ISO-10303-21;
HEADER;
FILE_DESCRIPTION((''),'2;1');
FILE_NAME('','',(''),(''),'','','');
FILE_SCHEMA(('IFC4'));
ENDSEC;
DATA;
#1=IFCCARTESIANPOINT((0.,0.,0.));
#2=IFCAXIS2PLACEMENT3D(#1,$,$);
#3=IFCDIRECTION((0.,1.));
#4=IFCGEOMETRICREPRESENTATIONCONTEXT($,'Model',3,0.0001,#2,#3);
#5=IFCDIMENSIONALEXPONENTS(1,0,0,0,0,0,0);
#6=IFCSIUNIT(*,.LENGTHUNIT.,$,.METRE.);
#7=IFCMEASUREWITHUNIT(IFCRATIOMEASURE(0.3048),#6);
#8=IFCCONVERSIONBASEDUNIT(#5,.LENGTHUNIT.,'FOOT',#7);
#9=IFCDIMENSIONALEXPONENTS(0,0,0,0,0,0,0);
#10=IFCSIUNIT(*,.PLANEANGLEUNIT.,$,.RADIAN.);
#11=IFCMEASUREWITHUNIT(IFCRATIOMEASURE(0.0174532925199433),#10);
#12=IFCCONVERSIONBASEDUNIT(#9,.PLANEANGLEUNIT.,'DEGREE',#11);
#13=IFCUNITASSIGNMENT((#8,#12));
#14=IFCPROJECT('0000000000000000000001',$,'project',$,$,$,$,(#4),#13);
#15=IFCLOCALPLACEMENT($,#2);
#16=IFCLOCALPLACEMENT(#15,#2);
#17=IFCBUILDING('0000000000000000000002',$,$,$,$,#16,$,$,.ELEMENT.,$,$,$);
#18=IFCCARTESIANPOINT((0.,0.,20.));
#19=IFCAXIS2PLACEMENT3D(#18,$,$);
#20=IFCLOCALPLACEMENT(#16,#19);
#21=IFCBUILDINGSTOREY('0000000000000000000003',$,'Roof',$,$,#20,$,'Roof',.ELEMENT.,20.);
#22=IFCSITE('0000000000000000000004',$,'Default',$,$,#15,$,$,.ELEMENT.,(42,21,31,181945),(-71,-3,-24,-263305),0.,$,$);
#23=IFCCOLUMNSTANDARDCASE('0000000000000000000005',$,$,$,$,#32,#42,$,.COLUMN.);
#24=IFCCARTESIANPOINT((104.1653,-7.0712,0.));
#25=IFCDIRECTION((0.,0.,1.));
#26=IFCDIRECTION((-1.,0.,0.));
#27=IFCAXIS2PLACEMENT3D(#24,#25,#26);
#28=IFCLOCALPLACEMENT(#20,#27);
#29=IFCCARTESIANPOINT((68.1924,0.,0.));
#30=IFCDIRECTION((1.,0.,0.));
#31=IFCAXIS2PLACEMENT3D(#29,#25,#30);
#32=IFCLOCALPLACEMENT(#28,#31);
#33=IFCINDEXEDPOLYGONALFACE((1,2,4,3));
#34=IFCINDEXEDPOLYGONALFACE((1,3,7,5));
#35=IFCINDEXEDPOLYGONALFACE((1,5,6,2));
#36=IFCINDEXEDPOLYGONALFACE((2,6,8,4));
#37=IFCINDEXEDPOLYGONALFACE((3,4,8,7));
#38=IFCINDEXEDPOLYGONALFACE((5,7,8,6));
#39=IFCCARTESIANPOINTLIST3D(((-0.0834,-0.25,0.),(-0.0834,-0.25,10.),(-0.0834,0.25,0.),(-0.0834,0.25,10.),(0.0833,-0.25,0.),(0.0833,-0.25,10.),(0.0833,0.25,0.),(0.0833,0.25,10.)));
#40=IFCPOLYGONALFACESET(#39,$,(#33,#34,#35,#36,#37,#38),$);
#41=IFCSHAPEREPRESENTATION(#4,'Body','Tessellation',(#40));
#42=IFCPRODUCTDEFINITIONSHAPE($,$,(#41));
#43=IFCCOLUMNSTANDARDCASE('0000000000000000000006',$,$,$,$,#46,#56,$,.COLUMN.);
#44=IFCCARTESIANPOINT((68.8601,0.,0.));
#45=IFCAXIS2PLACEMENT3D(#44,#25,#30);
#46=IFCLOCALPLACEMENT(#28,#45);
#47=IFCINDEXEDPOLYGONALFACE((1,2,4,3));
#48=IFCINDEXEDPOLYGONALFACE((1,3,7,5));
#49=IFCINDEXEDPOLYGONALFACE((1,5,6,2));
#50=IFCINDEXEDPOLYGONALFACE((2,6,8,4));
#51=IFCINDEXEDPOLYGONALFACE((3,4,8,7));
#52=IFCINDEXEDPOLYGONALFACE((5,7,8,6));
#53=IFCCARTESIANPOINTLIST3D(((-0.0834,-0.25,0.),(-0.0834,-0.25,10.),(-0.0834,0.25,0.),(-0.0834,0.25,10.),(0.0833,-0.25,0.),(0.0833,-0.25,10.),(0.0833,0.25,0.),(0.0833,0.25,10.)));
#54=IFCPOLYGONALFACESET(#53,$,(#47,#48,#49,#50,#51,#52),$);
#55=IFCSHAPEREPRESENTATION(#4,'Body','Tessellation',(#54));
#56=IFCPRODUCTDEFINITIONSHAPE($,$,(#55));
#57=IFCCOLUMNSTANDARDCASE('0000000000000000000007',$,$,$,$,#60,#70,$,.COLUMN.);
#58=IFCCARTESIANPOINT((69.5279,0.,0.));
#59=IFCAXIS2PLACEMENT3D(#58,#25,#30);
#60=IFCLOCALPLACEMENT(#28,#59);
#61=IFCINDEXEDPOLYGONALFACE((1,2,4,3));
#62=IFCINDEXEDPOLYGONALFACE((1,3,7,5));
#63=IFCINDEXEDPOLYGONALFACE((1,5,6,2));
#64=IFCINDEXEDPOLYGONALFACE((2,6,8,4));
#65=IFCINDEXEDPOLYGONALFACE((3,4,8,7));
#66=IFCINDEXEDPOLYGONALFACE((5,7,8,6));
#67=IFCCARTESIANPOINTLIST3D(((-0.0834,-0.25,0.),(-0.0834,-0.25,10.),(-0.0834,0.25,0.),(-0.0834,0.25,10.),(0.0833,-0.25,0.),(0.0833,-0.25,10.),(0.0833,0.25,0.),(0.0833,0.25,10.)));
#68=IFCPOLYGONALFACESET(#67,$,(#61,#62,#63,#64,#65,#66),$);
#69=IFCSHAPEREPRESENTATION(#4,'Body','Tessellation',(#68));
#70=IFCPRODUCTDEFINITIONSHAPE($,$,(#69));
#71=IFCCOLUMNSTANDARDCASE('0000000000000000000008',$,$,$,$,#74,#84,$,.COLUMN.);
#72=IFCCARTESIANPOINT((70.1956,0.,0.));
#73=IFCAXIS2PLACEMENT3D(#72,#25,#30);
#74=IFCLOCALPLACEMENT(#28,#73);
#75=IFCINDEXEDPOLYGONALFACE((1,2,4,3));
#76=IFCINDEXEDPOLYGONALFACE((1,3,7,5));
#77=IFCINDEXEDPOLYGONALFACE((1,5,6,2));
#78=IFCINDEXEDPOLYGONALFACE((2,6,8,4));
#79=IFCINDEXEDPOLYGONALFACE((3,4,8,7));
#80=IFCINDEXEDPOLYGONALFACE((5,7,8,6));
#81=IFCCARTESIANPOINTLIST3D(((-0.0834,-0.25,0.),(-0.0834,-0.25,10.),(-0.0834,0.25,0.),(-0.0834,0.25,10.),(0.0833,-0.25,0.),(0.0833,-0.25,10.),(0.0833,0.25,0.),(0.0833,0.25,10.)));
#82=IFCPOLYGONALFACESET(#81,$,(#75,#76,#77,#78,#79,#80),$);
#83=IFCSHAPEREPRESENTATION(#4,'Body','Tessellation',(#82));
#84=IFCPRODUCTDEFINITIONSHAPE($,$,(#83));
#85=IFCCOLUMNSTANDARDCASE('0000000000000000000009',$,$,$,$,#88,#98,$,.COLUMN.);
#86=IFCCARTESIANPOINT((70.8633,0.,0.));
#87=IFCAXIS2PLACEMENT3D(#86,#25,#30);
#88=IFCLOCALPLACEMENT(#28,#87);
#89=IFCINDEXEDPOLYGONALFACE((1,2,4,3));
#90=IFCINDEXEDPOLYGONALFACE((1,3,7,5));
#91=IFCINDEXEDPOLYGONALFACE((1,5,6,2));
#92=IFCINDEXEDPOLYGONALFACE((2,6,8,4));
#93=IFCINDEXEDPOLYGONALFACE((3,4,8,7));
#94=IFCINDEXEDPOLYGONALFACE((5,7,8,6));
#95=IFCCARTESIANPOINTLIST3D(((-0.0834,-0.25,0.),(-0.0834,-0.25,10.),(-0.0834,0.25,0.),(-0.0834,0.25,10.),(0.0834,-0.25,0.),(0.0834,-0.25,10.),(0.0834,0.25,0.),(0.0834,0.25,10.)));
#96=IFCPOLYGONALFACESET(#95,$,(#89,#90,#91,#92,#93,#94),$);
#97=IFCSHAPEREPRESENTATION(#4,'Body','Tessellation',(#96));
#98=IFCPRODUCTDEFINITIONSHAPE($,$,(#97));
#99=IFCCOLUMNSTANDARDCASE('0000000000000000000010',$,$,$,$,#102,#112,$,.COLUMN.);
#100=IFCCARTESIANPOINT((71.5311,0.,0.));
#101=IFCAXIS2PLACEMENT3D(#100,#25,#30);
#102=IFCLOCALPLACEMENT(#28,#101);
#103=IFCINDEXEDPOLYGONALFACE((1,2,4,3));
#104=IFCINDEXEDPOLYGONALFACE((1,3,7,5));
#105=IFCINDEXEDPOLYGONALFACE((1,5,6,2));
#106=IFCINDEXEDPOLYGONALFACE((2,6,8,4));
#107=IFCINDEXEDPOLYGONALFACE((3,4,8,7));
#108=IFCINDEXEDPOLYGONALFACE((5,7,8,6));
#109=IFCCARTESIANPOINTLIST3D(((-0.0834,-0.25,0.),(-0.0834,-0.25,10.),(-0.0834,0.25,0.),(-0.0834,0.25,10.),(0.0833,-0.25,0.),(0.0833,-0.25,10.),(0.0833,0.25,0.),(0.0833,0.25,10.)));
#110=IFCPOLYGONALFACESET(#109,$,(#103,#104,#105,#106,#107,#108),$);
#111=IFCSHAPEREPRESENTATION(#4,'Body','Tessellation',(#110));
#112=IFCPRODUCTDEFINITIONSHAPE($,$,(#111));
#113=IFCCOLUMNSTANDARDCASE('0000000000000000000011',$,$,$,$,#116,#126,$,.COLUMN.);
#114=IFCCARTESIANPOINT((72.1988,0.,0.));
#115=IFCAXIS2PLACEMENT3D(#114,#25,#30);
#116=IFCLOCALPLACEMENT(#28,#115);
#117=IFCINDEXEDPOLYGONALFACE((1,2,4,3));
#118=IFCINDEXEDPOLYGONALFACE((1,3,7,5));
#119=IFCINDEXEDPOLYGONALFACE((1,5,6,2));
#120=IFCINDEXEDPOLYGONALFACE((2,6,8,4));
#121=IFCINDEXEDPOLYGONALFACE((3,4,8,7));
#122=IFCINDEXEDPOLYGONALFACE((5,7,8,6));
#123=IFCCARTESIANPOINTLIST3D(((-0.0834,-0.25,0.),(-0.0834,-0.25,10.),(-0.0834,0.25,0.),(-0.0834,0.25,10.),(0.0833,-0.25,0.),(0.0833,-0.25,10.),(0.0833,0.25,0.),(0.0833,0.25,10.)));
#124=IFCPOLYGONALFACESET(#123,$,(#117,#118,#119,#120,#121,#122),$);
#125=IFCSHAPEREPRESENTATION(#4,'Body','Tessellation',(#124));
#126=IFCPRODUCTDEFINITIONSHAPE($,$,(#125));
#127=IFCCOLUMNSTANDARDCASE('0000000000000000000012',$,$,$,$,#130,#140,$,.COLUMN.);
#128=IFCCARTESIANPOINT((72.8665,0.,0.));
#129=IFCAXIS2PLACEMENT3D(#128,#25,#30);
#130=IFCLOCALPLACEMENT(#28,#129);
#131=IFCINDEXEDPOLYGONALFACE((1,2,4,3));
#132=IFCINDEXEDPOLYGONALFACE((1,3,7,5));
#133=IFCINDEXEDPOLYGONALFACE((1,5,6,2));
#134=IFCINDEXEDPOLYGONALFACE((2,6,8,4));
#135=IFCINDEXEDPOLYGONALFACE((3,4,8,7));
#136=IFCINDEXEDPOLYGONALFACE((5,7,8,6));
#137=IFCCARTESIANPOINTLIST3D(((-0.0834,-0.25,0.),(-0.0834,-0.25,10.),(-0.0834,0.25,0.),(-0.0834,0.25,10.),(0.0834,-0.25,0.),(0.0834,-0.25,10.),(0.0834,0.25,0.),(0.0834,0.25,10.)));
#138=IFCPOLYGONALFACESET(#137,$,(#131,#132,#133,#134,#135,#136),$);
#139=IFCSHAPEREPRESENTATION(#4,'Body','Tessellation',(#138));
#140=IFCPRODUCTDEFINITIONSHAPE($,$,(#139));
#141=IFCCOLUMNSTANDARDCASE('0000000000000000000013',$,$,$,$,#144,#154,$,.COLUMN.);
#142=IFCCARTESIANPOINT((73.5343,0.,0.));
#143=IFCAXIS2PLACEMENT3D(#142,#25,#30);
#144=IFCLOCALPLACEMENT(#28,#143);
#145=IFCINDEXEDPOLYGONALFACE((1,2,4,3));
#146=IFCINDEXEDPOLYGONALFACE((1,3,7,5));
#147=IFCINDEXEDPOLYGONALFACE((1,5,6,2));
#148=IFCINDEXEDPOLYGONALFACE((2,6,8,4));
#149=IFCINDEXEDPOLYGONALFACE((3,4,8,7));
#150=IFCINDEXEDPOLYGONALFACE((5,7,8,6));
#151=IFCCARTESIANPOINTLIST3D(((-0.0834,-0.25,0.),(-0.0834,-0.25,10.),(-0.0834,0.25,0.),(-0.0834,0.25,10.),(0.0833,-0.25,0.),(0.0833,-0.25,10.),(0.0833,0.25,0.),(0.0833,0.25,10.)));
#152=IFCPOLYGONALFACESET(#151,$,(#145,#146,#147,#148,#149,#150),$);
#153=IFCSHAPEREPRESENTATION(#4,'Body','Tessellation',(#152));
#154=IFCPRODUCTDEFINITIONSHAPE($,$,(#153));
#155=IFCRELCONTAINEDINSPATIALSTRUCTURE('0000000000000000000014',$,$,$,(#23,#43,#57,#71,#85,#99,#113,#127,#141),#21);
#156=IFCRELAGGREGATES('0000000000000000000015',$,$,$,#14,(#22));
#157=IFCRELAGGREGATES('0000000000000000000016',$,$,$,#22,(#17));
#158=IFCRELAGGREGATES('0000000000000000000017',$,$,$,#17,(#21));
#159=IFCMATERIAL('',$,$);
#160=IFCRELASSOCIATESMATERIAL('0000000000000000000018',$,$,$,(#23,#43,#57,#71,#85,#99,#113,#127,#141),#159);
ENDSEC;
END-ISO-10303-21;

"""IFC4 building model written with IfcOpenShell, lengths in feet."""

from ifc_helpers import new_model, entity, si_unit, converted_unit, direction, frame, origin, place, context, project, spatial, rectangle, extrude, material, element, save


model = new_model("IFC4")

# Units and contexts
model_context = context("Model", 3, precision=0.0001, world=origin(), true_north=direction((0.0, 1.0)))
ifc_project = project(units=[converted_unit("LENGTHUNIT", "FOOT", entity("IfcRatioMeasure", 0.3048), si_unit("LENGTHUNIT", "METRE"), dimensions=[1, 0, 0, 0, 0, 0, 0]), converted_unit("PLANEANGLEUNIT", "DEGREE", entity("IfcRatioMeasure", 0.0174532925199433), si_unit("PLANEANGLEUNIT", "RADIAN"), dimensions=[0, 0, 0, 0, 0, 0, 0])], contexts=[model_context])

# Site, building, storey
site_placement = place(None, origin())
site = spatial("IfcSite", under=ifc_project, at=site_placement, Name="Default", CompositionType="ELEMENT", RefLatitude=(42, 21, 31, 181945), RefLongitude=(-71, -3, -24, -263305), RefElevation=0.0)
building_placement = place(site_placement, origin())
building = spatial("IfcBuilding", under=site, at=building_placement, CompositionType="ELEMENT")
storey_placement = place(building_placement, frame((0.0, 0.0, 20.0)))
storey = spatial("IfcBuildingStorey", under=building, at=storey_placement, Name="Roof", LongName="Roof", CompositionType="ELEMENT", Elevation=20.0)

# Columns
ifc_material_1 = material(Name="")
placement_1 = place(storey_placement, frame((104.1653, -7.0712, 0.0), z_axis=(0.0, 0.0, 1.0), x_axis=(-1.0, 0.0, 0.0)))
for number, where, z_axis, x_axis in (
    (1, (68.1924, 0.0, 0.0), (0.0, 0.0, 1.0), (1.0, 0.0, 0.0)),
    (2, (68.8601, 0.0, 0.0), (0.0, 0.0, 1.0), (1.0, 0.0, 0.0)),
    (3, (69.5279, 0.0, 0.0), (0.0, 0.0, 1.0), (1.0, 0.0, 0.0)),
    (4, (70.1956, 0.0, 0.0), (0.0, 0.0, 1.0), (1.0, 0.0, 0.0)),
    (5, (70.8633, 0.0, 0.0), (0.0, 0.0, 1.0), (1.0, 0.0, 0.0)),
    (6, (71.5311, 0.0, 0.0), (0.0, 0.0, 1.0), (1.0, 0.0, 0.0)),
    (7, (72.1988, 0.0, 0.0), (0.0, 0.0, 1.0), (1.0, 0.0, 0.0)),
    (8, (72.8665, 0.0, 0.0), (0.0, 0.0, 1.0), (1.0, 0.0, 0.0)),
    (9, (73.5343, 0.0, 0.0), (0.0, 0.0, 1.0), (1.0, 0.0, 0.0)),
):
    element("IfcColumnStandardCase", number, at=place(placement_1, frame(where, z_axis=z_axis, x_axis=x_axis)), inside=storey, material=ifc_material_1, PredefinedType="COLUMN", context=model_context, shape_type="SweptSolid", body=[
        extrude(rectangle(XDim=0.1667, YDim=0.5), origin(), (0.0, 0.0, 1.0), 10.0),
    ])

save(model, "model.ifc")
